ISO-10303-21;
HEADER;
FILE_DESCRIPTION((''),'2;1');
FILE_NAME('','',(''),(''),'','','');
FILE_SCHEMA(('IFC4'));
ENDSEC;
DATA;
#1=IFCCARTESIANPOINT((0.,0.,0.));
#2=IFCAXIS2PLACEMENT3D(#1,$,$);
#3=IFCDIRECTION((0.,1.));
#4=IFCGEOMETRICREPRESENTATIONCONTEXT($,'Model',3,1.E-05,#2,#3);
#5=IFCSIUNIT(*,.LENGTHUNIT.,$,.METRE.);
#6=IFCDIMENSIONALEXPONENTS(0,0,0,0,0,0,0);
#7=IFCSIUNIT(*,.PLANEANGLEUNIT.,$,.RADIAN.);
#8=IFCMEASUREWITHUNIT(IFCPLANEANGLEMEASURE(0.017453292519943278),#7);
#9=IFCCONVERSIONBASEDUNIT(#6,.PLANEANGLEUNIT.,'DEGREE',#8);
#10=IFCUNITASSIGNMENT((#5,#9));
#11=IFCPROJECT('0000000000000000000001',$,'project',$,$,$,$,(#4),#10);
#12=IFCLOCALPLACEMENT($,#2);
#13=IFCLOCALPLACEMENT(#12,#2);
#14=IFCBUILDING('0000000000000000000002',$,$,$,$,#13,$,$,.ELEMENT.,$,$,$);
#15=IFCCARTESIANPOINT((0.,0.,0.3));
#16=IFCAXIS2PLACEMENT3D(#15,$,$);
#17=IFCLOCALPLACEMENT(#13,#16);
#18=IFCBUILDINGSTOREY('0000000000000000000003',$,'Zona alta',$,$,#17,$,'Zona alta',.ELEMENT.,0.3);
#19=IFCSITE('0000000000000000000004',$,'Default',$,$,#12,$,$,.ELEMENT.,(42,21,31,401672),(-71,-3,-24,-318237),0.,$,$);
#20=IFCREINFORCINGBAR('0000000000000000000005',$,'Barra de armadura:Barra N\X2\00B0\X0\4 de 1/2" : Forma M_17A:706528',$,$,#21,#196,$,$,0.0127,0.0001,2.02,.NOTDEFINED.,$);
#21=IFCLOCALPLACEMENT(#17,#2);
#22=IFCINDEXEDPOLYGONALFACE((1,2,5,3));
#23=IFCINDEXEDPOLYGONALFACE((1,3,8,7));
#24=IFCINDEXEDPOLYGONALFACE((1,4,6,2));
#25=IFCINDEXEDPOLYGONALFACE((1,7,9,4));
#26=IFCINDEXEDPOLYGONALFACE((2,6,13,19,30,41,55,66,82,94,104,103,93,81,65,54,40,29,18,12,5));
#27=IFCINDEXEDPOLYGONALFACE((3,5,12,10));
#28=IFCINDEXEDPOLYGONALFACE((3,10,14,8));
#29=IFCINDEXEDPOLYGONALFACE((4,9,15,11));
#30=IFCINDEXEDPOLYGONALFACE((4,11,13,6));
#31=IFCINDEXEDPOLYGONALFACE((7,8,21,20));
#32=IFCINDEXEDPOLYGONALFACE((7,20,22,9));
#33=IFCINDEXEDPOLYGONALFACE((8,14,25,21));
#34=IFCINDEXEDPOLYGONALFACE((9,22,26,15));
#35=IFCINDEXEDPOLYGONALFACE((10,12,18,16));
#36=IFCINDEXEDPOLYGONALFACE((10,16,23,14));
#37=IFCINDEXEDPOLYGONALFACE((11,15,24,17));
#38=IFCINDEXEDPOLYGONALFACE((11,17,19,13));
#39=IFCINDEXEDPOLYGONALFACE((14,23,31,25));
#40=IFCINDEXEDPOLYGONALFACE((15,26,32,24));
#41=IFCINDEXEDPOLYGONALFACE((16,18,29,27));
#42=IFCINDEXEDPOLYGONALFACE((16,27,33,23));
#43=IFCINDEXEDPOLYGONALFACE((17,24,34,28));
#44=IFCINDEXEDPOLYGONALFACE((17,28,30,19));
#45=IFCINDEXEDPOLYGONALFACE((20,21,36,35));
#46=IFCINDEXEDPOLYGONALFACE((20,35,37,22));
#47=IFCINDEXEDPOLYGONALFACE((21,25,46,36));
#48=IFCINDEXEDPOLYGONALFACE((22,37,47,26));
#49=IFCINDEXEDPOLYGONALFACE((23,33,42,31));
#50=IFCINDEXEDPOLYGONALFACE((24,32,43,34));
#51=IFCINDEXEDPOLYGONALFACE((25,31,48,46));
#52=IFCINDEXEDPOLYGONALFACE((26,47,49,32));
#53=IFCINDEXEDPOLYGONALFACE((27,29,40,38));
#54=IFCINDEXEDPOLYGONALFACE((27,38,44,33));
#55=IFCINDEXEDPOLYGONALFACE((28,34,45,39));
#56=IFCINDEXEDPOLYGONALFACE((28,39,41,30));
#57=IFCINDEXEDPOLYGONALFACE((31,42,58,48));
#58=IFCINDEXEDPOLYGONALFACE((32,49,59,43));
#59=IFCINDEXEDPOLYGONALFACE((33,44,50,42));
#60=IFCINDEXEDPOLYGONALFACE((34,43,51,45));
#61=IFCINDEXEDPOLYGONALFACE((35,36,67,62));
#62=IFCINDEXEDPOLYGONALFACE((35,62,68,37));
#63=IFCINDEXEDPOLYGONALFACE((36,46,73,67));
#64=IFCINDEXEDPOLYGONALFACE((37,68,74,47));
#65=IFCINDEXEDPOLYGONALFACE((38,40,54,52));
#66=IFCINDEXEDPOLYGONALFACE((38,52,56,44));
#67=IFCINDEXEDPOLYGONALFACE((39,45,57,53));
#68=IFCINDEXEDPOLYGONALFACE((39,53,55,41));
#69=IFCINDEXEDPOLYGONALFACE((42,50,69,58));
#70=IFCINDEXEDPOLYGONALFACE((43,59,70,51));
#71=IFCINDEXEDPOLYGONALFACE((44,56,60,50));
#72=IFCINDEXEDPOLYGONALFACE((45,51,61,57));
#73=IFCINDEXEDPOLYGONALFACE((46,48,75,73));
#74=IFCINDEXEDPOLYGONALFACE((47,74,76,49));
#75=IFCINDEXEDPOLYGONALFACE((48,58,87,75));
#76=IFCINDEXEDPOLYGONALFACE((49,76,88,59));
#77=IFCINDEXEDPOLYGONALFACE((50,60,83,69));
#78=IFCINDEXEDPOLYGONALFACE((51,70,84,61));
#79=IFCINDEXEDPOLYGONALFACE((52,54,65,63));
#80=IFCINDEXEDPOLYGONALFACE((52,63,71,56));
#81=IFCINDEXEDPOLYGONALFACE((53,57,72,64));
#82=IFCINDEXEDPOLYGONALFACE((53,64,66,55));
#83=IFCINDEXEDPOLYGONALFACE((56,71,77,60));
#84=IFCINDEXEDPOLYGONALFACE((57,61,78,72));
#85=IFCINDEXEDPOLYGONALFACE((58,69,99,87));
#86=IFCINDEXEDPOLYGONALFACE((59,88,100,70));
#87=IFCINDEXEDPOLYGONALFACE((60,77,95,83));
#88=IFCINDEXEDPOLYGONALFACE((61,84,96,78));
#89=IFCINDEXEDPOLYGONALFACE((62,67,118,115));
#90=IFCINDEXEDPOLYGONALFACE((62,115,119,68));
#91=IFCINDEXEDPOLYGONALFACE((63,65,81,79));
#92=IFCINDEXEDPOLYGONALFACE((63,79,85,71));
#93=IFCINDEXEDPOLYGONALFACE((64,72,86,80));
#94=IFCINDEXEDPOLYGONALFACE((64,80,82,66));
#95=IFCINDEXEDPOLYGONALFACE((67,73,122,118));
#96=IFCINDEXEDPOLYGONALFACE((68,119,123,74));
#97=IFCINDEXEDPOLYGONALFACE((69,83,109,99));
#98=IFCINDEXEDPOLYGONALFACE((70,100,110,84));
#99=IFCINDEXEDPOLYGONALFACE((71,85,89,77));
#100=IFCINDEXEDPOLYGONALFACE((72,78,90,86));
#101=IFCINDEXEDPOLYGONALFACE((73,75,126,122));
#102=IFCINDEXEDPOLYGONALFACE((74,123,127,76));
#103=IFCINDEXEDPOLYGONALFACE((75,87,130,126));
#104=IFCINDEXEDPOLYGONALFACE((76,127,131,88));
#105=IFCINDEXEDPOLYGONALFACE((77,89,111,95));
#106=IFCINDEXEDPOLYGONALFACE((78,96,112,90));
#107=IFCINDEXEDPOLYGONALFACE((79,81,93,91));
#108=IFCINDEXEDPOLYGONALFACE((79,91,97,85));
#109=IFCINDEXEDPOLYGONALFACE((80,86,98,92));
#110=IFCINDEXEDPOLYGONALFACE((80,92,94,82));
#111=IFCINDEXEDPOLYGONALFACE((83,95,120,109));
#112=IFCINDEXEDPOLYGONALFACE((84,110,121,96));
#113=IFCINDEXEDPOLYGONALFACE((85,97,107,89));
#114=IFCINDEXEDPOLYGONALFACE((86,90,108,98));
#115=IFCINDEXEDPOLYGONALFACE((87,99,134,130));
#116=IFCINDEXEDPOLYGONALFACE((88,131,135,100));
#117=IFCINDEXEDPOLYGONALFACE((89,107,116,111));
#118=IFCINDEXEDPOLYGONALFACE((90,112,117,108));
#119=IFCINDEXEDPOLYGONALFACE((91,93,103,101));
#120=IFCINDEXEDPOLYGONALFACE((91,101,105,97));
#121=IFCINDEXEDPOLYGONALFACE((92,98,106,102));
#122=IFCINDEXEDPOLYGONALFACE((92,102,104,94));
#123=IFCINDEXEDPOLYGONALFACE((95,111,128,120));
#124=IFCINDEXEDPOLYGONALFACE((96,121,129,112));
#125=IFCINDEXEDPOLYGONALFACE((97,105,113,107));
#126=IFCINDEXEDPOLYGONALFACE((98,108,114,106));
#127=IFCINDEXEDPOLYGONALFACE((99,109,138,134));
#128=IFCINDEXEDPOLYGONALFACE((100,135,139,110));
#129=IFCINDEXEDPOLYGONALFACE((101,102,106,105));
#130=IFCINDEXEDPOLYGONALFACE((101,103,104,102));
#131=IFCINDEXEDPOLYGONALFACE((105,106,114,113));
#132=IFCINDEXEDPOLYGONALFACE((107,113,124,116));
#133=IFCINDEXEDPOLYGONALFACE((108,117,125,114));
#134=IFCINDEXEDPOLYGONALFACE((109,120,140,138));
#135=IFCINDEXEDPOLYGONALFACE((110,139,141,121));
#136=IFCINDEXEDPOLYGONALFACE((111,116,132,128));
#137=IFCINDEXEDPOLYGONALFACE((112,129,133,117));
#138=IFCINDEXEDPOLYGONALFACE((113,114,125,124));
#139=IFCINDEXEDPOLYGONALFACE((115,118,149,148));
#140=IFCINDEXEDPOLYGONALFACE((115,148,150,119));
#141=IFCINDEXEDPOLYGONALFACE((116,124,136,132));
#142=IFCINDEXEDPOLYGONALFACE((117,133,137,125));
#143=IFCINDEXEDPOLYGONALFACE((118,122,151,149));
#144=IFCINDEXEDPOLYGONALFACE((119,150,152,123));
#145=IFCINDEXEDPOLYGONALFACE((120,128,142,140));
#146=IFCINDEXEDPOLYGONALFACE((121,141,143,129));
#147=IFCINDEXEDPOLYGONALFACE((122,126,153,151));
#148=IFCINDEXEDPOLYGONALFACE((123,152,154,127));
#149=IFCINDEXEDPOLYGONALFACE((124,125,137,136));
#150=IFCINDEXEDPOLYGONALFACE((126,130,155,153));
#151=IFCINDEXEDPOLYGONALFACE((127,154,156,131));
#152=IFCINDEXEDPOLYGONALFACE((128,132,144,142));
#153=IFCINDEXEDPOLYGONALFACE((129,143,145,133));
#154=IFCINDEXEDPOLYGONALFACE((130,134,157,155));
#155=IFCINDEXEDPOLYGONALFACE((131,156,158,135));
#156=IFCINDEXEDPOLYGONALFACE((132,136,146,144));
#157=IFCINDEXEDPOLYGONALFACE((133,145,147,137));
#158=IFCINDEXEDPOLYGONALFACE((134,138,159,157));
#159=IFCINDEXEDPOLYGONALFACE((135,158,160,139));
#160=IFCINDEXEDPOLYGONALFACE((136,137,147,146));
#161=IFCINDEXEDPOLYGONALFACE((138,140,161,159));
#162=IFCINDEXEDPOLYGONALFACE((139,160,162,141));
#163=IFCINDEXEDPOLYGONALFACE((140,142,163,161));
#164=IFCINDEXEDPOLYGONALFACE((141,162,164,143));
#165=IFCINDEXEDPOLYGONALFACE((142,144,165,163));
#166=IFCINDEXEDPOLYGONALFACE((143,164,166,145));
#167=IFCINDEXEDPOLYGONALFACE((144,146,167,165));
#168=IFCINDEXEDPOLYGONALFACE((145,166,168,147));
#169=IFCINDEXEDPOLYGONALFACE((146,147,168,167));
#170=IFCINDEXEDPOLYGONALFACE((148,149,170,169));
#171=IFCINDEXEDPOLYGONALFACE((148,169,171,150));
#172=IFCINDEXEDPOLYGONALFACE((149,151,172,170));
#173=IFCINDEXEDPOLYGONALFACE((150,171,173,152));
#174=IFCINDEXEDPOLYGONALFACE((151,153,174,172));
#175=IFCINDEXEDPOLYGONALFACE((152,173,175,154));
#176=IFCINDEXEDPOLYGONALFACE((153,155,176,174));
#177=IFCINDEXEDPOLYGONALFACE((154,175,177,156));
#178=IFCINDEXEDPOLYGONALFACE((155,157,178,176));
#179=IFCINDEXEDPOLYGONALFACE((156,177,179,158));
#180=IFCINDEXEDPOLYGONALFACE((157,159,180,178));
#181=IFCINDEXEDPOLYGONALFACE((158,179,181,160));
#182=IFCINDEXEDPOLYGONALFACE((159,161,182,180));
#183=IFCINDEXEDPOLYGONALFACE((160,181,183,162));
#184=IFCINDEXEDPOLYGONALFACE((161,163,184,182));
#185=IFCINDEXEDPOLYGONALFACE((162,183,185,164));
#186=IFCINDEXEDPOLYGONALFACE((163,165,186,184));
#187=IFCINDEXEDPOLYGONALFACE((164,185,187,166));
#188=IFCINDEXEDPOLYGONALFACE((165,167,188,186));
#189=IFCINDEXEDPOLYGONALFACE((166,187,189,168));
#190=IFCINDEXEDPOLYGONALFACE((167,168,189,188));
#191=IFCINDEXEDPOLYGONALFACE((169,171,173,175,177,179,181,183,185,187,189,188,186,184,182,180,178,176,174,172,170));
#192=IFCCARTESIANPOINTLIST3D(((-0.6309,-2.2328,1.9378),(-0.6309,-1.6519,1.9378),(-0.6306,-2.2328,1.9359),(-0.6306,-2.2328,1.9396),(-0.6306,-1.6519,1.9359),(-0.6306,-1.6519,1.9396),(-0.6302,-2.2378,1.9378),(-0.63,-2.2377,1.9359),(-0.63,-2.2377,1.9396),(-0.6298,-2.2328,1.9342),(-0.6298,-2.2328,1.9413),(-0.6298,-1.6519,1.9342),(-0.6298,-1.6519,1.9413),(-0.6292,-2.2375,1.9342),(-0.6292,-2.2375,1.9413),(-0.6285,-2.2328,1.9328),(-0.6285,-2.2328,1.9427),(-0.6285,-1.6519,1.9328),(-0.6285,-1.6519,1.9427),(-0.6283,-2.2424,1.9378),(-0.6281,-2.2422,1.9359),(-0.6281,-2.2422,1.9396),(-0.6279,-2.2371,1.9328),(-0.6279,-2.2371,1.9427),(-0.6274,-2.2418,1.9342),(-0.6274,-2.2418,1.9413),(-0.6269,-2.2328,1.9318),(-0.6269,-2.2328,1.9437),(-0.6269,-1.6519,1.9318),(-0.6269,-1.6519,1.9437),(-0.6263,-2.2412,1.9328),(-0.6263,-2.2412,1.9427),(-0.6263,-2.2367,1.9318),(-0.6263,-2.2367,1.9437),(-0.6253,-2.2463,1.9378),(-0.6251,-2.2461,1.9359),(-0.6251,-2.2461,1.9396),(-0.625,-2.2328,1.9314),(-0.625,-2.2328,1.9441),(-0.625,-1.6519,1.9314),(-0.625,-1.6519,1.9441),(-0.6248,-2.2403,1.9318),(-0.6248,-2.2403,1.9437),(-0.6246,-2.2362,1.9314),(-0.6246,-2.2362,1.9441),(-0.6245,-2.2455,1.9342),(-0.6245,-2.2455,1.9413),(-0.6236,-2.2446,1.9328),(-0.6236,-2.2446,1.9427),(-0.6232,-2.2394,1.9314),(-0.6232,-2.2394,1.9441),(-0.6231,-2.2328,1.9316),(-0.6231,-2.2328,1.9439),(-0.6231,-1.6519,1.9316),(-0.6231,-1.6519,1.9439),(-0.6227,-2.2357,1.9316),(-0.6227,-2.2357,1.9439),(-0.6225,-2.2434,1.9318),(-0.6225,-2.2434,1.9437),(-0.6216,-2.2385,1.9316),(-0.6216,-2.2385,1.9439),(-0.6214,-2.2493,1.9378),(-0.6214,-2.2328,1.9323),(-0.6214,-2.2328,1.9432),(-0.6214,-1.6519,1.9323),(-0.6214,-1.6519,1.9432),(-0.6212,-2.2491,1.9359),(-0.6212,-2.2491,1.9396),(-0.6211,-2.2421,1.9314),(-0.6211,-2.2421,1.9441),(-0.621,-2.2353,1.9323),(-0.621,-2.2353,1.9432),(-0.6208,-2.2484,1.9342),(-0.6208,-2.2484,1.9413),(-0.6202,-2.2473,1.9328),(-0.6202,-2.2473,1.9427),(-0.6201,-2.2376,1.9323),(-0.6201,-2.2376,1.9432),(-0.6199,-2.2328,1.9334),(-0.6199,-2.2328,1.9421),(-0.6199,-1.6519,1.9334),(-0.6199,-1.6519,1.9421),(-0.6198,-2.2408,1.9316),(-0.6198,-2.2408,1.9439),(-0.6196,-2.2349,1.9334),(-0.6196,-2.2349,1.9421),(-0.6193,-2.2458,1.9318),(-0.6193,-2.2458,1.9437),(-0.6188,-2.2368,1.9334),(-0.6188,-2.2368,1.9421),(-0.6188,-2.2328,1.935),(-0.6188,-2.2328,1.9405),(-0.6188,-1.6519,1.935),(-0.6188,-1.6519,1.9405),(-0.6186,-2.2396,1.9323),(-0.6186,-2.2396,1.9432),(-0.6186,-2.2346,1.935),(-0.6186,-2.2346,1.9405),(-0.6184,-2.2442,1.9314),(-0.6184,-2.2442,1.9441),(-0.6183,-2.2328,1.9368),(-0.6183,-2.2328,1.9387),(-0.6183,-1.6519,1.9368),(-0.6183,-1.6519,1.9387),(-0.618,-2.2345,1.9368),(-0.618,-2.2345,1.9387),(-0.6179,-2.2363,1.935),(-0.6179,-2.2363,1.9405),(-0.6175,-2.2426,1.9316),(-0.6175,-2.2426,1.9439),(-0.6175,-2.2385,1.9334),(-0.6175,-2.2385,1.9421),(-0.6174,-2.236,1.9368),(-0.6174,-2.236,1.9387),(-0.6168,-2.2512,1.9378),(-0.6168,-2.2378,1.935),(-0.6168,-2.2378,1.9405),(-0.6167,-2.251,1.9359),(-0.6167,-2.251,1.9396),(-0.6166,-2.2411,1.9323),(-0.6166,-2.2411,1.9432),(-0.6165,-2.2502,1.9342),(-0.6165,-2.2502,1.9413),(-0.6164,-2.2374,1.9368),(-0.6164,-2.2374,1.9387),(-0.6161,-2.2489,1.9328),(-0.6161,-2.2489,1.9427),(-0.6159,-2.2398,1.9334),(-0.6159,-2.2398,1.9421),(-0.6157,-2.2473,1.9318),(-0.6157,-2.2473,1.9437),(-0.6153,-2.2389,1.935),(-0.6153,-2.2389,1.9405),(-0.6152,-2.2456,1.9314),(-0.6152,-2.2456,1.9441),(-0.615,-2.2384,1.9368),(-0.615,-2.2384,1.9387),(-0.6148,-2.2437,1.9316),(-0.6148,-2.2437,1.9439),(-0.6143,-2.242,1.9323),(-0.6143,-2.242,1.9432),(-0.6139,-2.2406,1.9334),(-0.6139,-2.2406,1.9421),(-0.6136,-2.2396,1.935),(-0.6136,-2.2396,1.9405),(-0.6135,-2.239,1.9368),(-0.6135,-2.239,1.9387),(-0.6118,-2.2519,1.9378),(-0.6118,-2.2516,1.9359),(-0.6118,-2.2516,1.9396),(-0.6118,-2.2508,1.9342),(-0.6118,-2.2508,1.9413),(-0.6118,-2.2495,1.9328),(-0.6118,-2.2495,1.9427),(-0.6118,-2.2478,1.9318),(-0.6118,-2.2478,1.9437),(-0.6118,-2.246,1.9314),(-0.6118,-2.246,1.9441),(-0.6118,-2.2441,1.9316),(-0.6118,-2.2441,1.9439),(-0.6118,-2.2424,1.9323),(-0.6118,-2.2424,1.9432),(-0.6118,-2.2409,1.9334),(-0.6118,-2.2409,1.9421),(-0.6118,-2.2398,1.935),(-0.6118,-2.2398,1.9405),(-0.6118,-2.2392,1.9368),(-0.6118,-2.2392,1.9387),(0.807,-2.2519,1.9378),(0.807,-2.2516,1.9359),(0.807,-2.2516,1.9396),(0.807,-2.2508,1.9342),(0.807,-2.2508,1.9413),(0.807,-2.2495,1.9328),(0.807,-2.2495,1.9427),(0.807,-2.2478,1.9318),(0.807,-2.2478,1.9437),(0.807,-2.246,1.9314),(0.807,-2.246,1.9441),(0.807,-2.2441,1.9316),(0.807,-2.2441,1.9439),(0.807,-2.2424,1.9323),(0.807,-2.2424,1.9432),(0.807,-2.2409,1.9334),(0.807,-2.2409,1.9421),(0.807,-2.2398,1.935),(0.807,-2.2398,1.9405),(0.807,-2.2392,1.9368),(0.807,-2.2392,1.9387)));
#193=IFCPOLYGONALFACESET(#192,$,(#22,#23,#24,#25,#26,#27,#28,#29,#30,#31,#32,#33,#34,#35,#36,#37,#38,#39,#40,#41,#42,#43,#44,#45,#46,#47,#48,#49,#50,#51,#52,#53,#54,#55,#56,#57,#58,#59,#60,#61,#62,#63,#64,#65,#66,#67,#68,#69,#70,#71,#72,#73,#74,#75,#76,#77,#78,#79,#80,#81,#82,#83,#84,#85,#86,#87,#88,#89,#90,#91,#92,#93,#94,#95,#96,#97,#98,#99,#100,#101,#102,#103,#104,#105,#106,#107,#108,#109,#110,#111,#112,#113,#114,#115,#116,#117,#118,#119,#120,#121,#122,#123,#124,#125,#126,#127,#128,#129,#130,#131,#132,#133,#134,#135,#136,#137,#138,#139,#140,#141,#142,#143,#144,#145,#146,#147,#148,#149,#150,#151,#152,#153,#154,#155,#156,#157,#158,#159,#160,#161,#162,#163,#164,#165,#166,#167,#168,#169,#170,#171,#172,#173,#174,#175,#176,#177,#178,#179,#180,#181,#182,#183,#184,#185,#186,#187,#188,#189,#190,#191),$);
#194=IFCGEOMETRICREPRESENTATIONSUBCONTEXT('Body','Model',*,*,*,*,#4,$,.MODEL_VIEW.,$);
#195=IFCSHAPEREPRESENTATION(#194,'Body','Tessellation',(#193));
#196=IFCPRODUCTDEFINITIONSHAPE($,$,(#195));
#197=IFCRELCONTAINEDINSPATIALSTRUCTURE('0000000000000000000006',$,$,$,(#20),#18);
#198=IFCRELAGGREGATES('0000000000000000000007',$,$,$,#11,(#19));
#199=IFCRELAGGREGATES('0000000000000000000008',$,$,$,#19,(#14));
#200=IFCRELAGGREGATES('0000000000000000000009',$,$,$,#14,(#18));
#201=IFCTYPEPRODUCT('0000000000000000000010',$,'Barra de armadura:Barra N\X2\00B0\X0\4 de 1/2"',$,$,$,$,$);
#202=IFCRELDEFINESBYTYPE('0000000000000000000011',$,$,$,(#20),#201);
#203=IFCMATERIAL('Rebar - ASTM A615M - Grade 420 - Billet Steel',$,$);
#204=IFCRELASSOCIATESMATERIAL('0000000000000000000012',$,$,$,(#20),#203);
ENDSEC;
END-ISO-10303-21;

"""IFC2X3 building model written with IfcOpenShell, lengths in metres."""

from ifc_helpers import new_model, entity, si_unit, converted_unit, direction, frame, origin, place, context, subcontext, project, spatial, material, type_object, element, save


model = new_model("IFC2X3")

# Units and contexts
model_context = context("Model", 3, precision=1e-05, world=origin(), true_north=direction((0.0, 1.0)))
body_context = subcontext(model_context, "Body", "Model", "MODEL_VIEW")
ifc_project = project(units=[si_unit("LENGTHUNIT", "METRE"), converted_unit("PLANEANGLEUNIT", "DEGREE", entity("IfcPlaneAngleMeasure", 0.017453292519943278), si_unit("PLANEANGLEUNIT", "RADIAN"), dimensions=[0, 0, 0, 0, 0, 0, 0])], contexts=[model_context])

# Site, building, storey
site_placement = place(None, origin())
site = spatial("IfcSite", under=ifc_project, at=site_placement, Name="Default", CompositionType="ELEMENT", RefLatitude=(42, 21, 31, 401672), RefLongitude=(-71, -3, -24, -318237), RefElevation=0.0)
building_placement = place(site_placement, origin())
building = spatial("IfcBuilding", under=site, at=building_placement, CompositionType="ELEMENT")
storey_placement = place(building_placement, frame((0.0, 0.0, 0.3)))
storey = spatial("IfcBuildingStorey", under=building, at=storey_placement, Name="Zona alta", LongName="Zona alta", CompositionType="ELEMENT", Elevation=0.3)

# Reinforcing bar
ifc_material = material(Name="Rebar - ASTM A615M - Grade 420 - Billet Steel")
type_product_1 = type_object("IfcTypeProduct", Name="Barra de armadura:Barra N°4 de 1/2\"")
reinforcing_bar_1_placement = place(storey_placement, origin())
element("IfcReinforcingBar", 1, at=reinforcing_bar_1_placement, inside=storey, type_object=type_product_1, material=ifc_material, Name="Barra de armadura:Barra N°4 de 1/2\" : Forma M_17A:706528", BarLength=2.02, BarRole="NOTDEFINED", CrossSectionArea=0.0001, NominalDiameter=0.0127, context=body_context, shape_type="AdvancedSweptSolid", body=[
    entity("IfcSweptDiskSolid", entity("IfcCompositeCurve", [entity("IfcCompositeCurveSegment", "CONTINUOUS", True, entity("IfcPolyline", [entity("IfcCartesianPoint", [0.807, -2.2455, 1.9378]), entity("IfcCartesianPoint", [-0.6118, -2.2455, 1.9378])])), entity("IfcCompositeCurveSegment", "CONTINUOUS", True, entity("IfcTrimmedCurve", entity("IfcCircle", entity("IfcAxis2Placement3D", entity("IfcCartesianPoint", [-0.6118, -2.2328, 1.9378]), entity("IfcDirection", [0.0, 0.0, -1.0]), entity("IfcDirection", [-1.0, 0.0, 0.0])), 0.0127), [entity("IfcParameterValue", 270.0)], [entity("IfcParameterValue", 360.0)], True, "PARAMETER")), entity("IfcCompositeCurveSegment", "CONTINUOUS", True, entity("IfcPolyline", [entity("IfcCartesianPoint", [-0.6245, -2.2328, 1.9378]), entity("IfcCartesianPoint", [-0.6245, -1.6519, 1.9378])]))], False), 0.0063, None, 0.0, 92.0),
])

save(model, "model.ifc")
